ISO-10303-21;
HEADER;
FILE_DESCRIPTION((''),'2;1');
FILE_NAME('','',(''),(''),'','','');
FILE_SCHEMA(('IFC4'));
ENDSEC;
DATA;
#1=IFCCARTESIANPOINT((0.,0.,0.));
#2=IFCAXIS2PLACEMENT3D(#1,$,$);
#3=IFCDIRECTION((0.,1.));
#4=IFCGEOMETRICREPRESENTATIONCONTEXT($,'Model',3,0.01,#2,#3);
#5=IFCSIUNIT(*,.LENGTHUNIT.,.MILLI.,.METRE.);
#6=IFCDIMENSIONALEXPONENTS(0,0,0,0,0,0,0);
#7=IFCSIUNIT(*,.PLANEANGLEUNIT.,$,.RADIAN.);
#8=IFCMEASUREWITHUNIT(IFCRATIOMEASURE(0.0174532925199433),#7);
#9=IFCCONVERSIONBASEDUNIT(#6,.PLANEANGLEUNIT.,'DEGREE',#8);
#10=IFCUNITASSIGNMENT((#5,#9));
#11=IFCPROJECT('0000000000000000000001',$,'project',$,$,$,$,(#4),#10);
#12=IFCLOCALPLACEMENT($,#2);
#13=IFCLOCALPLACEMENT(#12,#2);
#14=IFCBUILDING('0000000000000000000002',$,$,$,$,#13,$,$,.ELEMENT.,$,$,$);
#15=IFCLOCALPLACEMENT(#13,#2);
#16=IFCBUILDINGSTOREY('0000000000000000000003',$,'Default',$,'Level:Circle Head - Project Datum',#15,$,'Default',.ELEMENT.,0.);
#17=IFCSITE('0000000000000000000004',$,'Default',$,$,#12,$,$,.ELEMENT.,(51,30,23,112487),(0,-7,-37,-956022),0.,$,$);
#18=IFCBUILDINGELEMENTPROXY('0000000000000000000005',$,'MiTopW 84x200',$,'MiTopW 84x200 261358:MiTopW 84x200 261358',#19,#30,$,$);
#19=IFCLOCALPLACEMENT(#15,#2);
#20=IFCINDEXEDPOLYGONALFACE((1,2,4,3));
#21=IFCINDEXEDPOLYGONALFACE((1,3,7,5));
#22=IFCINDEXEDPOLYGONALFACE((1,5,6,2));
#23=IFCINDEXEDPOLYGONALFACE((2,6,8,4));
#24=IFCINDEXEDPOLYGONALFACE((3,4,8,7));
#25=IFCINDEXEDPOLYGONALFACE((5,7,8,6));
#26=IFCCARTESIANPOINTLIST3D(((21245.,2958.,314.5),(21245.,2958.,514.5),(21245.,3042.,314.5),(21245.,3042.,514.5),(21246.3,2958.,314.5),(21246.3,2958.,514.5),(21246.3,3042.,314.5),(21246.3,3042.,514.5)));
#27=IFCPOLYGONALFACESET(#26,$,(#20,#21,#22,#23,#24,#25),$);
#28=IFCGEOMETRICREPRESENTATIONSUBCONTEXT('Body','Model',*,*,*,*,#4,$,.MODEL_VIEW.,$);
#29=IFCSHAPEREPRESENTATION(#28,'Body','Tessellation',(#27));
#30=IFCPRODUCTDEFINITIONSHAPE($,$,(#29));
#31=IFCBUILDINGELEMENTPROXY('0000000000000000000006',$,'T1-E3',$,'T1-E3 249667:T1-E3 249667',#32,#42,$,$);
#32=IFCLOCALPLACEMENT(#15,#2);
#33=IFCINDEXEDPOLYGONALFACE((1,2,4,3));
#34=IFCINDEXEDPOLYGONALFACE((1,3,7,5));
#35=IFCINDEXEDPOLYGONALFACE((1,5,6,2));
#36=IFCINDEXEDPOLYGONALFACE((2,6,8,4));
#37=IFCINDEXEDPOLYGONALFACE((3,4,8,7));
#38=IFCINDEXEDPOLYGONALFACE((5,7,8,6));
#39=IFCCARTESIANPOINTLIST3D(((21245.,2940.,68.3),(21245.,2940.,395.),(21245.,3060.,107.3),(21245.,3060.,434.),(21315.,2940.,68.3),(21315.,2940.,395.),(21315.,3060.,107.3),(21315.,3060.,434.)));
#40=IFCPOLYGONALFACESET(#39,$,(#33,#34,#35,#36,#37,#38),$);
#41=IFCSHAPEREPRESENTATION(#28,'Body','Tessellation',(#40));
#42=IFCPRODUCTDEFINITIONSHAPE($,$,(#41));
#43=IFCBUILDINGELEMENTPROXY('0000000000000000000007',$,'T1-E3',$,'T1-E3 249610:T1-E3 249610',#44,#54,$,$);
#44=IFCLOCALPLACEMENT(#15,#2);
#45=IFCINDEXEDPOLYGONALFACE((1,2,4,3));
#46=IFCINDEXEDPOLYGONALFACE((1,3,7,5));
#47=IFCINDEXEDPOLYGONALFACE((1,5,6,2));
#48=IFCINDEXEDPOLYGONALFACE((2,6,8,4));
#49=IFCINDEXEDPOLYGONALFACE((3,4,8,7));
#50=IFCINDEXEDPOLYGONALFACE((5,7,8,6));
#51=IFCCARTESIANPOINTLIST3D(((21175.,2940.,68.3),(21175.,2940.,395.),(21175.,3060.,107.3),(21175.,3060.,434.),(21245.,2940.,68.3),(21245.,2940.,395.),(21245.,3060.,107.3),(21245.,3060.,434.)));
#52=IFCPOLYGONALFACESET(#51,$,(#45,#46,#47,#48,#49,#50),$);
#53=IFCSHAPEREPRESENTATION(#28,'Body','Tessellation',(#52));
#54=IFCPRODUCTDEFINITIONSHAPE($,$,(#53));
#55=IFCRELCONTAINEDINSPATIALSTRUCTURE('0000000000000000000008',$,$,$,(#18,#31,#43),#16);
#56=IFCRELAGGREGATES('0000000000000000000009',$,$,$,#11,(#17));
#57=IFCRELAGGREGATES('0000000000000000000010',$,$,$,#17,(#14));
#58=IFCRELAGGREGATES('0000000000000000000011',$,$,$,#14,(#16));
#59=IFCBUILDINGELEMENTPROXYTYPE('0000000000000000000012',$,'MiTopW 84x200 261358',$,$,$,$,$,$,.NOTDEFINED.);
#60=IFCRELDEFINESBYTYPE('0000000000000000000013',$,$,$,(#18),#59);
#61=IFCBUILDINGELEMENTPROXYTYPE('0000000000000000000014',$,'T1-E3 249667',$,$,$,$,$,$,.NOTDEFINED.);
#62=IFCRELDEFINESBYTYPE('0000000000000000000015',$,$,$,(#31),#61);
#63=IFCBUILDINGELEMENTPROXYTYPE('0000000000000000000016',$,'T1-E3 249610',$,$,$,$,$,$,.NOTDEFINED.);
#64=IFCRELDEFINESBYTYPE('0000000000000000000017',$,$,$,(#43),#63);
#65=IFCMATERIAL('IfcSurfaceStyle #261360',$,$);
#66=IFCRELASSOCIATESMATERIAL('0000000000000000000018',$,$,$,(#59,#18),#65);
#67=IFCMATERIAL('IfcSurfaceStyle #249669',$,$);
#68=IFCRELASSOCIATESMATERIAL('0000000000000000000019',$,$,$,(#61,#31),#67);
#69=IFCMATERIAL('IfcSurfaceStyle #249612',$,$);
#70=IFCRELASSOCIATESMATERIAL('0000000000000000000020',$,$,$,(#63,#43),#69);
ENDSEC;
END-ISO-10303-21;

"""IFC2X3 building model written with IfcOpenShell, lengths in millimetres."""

from ifc_helpers import new_model, entity, si_unit, converted_unit, direction, frame, frame_2d, origin, place, context, subcontext, project, spatial, polyline, rectangle, outline, extrude, source, transform, mapped, material, type_object, type_shapes, element, save


model = new_model("IFC2X3")

# Units and contexts
model_context = context("Model", 3, precision=0.01, world=origin(), true_north=direction((0.0, 1.0)))
body_context = subcontext(model_context, "Body", "Model", "MODEL_VIEW")
ifc_project = project(units=[si_unit("LENGTHUNIT", "METRE", prefix="MILLI"), converted_unit("PLANEANGLEUNIT", "DEGREE", entity("IfcRatioMeasure", 0.0174532925199433), si_unit("PLANEANGLEUNIT", "RADIAN"), dimensions=[0, 0, 0, 0, 0, 0, 0])], contexts=[model_context])

# Site, building, storey
site_placement = place(None, origin())
site = spatial("IfcSite", under=ifc_project, at=site_placement, Name="Default", CompositionType="ELEMENT", RefLatitude=(51, 30, 23, 112487), RefLongitude=(0, -7, -37, -956022), RefElevation=0.0)
building_placement = place(site_placement, origin())
building = spatial("IfcBuilding", under=site, at=building_placement, CompositionType="ELEMENT")
storey_placement = place(building_placement, origin())
storey = spatial("IfcBuildingStorey", under=building, at=storey_placement, Name="Default", ObjectType="Level:Circle Head - Project Datum", LongName="Default", CompositionType="ELEMENT", Elevation=0.0)

# Building element proxies
ifc_material_1 = material(Name="IfcSurfaceStyle #261360")
building_element_proxy_type_1 = type_object("IfcBuildingElementProxyType", Name="MiTopW 84x200 261358", PredefinedType="NOTDEFINED", material=ifc_material_1)
shared_shape_1 = source(origin(), body_context, "Body", "SweptSolid", [
    extrude(rectangle(XDim=200.0, YDim=84.0, at=frame_2d((0.0, 0.0), x_axis=(1.0, 0.0))), frame((100.0, 42.0, 0.0), z_axis=(0.0, 0.0, 1.0), x_axis=(-1.0, 0.0, 0.0)), (0.0, 0.0, 1.0), 1.3),
])
type_shapes(building_element_proxy_type_1, [shared_shape_1])
proxy_1_placement = place(building_placement, frame((21246.3, 3042.0, 514.5), z_axis=(-1.0, 0.0, 0.0), x_axis=(0.0, 0.0, -1.0)))
element("IfcBuildingElementProxy", 1, at=proxy_1_placement, inside=storey, type_object=building_element_proxy_type_1, material=ifc_material_1, Name="MiTopW 84x200", ObjectType="MiTopW 84x200 261358:MiTopW 84x200 261358", context=body_context, shape_type="MappedRepresentation", body=[
    mapped(shared_shape_1, transform((0.0, 0.0, 0.0), scale=1.0)),
])
ifc_material_2 = material(Name="IfcSurfaceStyle #249669")
building_element_proxy_type_2 = type_object("IfcBuildingElementProxyType", Name="T1-E3 249667", PredefinedType="NOTDEFINED", material=ifc_material_2)
shared_shape_2 = source(origin(), body_context, "Body", "SweptSolid", [
    extrude(outline(polyline([(-182.8, -60.0), (143.8, -60.0), (182.8, 60.0), (-143.8, 60.0), (-182.8, -60.0)])), frame((182.8, 60.0, 0.0), z_axis=(0.0, 0.0, 1.0), x_axis=(-1.0, 0.0, 0.0)), (0.0, 0.0, 1.0), 70.0),
])
type_shapes(building_element_proxy_type_2, [shared_shape_2])
proxy_2_placement = place(building_placement, frame((21315.0, 2940.0, 68.3), z_axis=(-1.0, 0.0, 0.0), x_axis=(0.0, 0.0, 1.0)))
element("IfcBuildingElementProxy", 2, at=proxy_2_placement, inside=storey, type_object=building_element_proxy_type_2, material=ifc_material_2, Name="T1-E3", ObjectType="T1-E3 249667:T1-E3 249667", context=body_context, shape_type="MappedRepresentation", body=[
    mapped(shared_shape_2, transform((0.0, 0.0, 0.0), scale=1.0)),
])
ifc_material_3 = material(Name="IfcSurfaceStyle #249612")
building_element_proxy_type_3 = type_object("IfcBuildingElementProxyType", Name="T1-E3 249610", PredefinedType="NOTDEFINED", material=ifc_material_3)
shared_shape_3 = source(origin(), body_context, "Body", "SweptSolid", [
    extrude(outline(polyline([(-182.8, -60.0), (143.8, -60.0), (182.8, 60.0), (-143.8, 60.0), (-182.8, -60.0)])), frame((182.8, 60.0, 0.0), z_axis=(0.0, 0.0, 1.0), x_axis=(-1.0, 0.0, 0.0)), (0.0, 0.0, 1.0), 70.0),
])
type_shapes(building_element_proxy_type_3, [shared_shape_3])
proxy_3_placement = place(building_placement, frame((21245.0, 2940.0, 68.3), z_axis=(-1.0, 0.0, 0.0), x_axis=(0.0, 0.0, 1.0)))
element("IfcBuildingElementProxy", 3, at=proxy_3_placement, inside=storey, type_object=building_element_proxy_type_3, material=ifc_material_3, Name="T1-E3", ObjectType="T1-E3 249610:T1-E3 249610", context=body_context, shape_type="MappedRepresentation", body=[
    mapped(shared_shape_3, transform((0.0, 0.0, 0.0), scale=1.0)),
])

save(model, "model.ifc")
